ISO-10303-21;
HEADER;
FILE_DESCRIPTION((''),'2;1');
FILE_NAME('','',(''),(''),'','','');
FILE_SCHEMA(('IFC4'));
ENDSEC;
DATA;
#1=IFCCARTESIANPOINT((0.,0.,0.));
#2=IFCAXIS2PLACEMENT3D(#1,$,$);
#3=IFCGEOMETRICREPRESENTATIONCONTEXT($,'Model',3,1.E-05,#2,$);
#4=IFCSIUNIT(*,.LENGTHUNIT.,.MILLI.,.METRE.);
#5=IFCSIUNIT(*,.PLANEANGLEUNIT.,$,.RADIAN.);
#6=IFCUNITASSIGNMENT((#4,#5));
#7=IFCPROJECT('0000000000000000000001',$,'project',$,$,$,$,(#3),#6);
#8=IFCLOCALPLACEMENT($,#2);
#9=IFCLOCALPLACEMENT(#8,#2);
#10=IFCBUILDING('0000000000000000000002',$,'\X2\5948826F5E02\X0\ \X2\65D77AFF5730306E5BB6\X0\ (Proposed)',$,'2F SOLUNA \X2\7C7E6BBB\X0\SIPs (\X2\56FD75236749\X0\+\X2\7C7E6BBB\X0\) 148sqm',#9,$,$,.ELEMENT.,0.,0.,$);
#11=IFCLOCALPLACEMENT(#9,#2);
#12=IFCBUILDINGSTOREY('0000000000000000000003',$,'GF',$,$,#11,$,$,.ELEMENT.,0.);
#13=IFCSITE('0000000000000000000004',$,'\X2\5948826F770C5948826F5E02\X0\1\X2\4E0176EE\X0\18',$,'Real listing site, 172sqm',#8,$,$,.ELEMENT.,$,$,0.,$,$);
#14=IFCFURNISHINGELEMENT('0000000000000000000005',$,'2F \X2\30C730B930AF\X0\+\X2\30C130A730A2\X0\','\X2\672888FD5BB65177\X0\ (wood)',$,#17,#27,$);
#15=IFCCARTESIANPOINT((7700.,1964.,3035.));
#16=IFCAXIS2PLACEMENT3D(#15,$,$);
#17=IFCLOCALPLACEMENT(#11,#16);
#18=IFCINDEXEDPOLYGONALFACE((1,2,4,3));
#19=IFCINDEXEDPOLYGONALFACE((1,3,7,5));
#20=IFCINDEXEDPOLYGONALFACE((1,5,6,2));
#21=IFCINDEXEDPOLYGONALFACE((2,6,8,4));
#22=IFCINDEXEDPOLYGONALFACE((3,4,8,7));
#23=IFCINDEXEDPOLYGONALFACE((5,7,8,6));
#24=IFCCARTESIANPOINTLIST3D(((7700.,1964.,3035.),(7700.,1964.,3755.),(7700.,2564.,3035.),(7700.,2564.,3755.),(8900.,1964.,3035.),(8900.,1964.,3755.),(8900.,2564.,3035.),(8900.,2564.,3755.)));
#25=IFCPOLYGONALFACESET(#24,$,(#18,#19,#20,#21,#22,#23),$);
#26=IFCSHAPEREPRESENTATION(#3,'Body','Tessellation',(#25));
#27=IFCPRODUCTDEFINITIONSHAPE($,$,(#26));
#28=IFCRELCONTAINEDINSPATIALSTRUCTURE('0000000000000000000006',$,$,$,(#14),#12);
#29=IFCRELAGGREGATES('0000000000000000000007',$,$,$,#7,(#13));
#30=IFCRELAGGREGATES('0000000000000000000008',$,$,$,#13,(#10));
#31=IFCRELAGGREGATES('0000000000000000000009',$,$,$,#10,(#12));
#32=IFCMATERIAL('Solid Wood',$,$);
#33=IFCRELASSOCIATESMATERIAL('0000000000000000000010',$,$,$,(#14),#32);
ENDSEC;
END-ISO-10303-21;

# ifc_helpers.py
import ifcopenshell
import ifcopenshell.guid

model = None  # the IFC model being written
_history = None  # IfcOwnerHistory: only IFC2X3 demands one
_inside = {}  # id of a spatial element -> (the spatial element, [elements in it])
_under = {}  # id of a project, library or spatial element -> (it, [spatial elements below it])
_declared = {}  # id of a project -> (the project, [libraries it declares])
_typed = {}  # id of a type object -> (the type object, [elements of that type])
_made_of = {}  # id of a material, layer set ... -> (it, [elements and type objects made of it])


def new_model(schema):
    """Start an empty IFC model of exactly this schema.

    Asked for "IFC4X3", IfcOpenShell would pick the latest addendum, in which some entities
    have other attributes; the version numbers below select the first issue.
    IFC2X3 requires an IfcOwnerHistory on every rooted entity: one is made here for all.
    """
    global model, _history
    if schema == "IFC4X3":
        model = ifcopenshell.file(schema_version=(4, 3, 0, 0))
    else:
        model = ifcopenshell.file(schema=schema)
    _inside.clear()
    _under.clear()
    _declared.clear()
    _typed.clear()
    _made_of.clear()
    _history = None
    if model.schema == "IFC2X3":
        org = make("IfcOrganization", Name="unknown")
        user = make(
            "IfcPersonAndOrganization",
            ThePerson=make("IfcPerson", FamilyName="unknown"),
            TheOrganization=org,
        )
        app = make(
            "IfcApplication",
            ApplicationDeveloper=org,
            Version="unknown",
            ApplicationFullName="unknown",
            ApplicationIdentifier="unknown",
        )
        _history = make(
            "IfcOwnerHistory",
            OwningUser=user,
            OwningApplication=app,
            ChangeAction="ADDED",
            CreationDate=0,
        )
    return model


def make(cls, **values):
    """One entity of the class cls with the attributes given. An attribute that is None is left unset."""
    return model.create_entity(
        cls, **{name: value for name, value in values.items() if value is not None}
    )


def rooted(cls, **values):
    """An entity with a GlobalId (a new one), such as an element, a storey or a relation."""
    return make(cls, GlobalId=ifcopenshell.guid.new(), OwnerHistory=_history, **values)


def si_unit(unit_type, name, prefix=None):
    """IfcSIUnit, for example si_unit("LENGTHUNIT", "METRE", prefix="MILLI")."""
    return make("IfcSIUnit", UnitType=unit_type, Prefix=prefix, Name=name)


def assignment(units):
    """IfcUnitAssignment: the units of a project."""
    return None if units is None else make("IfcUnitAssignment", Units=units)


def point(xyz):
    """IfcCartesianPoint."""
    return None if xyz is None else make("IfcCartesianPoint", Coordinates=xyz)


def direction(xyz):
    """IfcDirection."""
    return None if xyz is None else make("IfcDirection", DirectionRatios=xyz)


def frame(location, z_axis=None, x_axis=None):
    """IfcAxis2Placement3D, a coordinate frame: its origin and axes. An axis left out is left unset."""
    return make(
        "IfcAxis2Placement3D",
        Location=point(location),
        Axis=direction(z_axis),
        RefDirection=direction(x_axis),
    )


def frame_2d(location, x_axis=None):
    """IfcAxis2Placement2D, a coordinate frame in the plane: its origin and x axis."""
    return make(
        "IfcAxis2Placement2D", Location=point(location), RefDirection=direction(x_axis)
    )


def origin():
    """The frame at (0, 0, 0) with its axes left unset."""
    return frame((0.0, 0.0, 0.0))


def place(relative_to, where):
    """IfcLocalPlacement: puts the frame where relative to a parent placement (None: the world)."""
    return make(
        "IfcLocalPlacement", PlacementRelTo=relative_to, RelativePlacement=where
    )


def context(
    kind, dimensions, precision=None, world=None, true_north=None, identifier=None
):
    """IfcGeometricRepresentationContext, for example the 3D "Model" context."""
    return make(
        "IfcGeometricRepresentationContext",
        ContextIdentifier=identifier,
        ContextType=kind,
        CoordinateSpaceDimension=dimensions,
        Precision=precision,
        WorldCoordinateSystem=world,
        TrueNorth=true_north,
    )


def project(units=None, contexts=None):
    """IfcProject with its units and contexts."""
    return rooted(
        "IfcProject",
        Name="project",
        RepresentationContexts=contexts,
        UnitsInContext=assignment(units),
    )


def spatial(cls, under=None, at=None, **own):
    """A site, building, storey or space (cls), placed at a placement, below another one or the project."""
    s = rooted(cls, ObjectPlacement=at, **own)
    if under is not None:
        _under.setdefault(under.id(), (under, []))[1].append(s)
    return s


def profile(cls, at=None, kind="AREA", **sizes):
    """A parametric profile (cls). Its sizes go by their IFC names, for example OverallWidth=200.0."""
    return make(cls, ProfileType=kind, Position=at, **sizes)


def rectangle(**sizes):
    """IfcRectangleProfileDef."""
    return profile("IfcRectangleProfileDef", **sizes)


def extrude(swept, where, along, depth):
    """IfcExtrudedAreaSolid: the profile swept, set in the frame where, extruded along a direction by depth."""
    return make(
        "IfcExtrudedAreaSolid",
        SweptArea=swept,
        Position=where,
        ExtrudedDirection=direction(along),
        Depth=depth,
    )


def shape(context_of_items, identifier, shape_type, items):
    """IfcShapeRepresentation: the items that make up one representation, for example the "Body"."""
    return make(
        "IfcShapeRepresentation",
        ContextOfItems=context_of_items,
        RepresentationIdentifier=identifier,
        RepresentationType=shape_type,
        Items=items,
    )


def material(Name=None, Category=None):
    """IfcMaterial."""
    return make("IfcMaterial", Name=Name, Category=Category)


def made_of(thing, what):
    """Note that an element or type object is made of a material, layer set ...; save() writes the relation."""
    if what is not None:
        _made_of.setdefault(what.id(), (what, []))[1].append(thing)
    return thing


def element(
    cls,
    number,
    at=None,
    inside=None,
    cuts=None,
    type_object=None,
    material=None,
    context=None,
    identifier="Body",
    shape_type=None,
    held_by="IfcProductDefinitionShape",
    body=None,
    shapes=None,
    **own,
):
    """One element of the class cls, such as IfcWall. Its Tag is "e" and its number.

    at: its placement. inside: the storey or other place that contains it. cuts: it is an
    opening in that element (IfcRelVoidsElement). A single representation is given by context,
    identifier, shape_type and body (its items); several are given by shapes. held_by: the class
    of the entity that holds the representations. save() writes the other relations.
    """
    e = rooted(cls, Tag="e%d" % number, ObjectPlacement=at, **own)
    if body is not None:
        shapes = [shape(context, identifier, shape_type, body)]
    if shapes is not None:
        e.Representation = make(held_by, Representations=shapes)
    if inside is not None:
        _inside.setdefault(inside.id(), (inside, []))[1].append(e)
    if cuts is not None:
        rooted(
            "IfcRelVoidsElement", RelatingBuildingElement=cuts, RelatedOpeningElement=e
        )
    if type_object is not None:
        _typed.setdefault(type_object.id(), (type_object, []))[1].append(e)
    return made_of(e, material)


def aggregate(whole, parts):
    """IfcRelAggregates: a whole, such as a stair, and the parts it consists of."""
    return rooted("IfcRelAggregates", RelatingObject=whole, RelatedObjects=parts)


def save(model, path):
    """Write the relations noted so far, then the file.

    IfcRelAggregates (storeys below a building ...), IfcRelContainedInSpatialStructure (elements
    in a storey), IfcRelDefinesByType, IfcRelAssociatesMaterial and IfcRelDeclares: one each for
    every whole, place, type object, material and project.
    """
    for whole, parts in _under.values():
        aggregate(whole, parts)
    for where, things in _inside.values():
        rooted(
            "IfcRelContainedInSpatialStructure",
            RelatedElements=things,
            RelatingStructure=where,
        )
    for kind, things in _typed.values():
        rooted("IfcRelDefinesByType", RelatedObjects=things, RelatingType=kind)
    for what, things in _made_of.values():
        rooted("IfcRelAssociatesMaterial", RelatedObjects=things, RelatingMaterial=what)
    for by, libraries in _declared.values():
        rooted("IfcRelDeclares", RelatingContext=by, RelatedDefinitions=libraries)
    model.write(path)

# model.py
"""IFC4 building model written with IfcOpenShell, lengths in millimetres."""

from ifc_helpers import new_model, si_unit, frame, frame_2d, origin, place, context, project, spatial, rectangle, extrude, material, element, save


model = new_model("IFC4")

# Units and contexts
model_context = context("Model", 3, precision=1e-05, world=origin())
ifc_project = project(units=[si_unit("LENGTHUNIT", "METRE", prefix="MILLI"), si_unit("PLANEANGLEUNIT", "RADIAN")], contexts=[model_context])

# Site, building, storey
site_placement = place(None, origin())
site = spatial("IfcSite", under=ifc_project, at=site_placement, Name="奈良県奈良市1丁目18", ObjectType="Real listing site, 172sqm", CompositionType="ELEMENT", RefElevation=0.0)
building_placement = place(site_placement, origin())
building = spatial("IfcBuilding", under=site, at=building_placement, Name="奈良市 旗竿地の家 (Proposed)", ObjectType="2F SOLUNA 籾殻SIPs (国産杉+籾殻) 148sqm", CompositionType="ELEMENT", ElevationOfRefHeight=0.0, ElevationOfTerrain=0.0)
storey_placement = place(building_placement, origin())
storey = spatial("IfcBuildingStorey", under=building, at=storey_placement, Name="GF", CompositionType="ELEMENT", Elevation=0.0)

# Shared definitions
ifc_material_1 = material(Name="Solid Wood")

# Furnishing element
furnishing_1_placement = place(storey_placement, frame((7700.0, 1964.0, 3035.0)))
element("IfcFurnishingElement", 1, at=furnishing_1_placement, inside=storey, material=ifc_material_1, Name="2F デスク+チェア", Description="木製家具 (wood)", context=model_context, shape_type="SweptSolid", body=[
    extrude(rectangle(XDim=1200.0, YDim=600.0, at=frame_2d((600.0, 300.0))), frame((7700.0, 1964.0, 3035.0)), (0.0, 0.0, 1.0), 720.0),
])

save(model, "model.ifc")
